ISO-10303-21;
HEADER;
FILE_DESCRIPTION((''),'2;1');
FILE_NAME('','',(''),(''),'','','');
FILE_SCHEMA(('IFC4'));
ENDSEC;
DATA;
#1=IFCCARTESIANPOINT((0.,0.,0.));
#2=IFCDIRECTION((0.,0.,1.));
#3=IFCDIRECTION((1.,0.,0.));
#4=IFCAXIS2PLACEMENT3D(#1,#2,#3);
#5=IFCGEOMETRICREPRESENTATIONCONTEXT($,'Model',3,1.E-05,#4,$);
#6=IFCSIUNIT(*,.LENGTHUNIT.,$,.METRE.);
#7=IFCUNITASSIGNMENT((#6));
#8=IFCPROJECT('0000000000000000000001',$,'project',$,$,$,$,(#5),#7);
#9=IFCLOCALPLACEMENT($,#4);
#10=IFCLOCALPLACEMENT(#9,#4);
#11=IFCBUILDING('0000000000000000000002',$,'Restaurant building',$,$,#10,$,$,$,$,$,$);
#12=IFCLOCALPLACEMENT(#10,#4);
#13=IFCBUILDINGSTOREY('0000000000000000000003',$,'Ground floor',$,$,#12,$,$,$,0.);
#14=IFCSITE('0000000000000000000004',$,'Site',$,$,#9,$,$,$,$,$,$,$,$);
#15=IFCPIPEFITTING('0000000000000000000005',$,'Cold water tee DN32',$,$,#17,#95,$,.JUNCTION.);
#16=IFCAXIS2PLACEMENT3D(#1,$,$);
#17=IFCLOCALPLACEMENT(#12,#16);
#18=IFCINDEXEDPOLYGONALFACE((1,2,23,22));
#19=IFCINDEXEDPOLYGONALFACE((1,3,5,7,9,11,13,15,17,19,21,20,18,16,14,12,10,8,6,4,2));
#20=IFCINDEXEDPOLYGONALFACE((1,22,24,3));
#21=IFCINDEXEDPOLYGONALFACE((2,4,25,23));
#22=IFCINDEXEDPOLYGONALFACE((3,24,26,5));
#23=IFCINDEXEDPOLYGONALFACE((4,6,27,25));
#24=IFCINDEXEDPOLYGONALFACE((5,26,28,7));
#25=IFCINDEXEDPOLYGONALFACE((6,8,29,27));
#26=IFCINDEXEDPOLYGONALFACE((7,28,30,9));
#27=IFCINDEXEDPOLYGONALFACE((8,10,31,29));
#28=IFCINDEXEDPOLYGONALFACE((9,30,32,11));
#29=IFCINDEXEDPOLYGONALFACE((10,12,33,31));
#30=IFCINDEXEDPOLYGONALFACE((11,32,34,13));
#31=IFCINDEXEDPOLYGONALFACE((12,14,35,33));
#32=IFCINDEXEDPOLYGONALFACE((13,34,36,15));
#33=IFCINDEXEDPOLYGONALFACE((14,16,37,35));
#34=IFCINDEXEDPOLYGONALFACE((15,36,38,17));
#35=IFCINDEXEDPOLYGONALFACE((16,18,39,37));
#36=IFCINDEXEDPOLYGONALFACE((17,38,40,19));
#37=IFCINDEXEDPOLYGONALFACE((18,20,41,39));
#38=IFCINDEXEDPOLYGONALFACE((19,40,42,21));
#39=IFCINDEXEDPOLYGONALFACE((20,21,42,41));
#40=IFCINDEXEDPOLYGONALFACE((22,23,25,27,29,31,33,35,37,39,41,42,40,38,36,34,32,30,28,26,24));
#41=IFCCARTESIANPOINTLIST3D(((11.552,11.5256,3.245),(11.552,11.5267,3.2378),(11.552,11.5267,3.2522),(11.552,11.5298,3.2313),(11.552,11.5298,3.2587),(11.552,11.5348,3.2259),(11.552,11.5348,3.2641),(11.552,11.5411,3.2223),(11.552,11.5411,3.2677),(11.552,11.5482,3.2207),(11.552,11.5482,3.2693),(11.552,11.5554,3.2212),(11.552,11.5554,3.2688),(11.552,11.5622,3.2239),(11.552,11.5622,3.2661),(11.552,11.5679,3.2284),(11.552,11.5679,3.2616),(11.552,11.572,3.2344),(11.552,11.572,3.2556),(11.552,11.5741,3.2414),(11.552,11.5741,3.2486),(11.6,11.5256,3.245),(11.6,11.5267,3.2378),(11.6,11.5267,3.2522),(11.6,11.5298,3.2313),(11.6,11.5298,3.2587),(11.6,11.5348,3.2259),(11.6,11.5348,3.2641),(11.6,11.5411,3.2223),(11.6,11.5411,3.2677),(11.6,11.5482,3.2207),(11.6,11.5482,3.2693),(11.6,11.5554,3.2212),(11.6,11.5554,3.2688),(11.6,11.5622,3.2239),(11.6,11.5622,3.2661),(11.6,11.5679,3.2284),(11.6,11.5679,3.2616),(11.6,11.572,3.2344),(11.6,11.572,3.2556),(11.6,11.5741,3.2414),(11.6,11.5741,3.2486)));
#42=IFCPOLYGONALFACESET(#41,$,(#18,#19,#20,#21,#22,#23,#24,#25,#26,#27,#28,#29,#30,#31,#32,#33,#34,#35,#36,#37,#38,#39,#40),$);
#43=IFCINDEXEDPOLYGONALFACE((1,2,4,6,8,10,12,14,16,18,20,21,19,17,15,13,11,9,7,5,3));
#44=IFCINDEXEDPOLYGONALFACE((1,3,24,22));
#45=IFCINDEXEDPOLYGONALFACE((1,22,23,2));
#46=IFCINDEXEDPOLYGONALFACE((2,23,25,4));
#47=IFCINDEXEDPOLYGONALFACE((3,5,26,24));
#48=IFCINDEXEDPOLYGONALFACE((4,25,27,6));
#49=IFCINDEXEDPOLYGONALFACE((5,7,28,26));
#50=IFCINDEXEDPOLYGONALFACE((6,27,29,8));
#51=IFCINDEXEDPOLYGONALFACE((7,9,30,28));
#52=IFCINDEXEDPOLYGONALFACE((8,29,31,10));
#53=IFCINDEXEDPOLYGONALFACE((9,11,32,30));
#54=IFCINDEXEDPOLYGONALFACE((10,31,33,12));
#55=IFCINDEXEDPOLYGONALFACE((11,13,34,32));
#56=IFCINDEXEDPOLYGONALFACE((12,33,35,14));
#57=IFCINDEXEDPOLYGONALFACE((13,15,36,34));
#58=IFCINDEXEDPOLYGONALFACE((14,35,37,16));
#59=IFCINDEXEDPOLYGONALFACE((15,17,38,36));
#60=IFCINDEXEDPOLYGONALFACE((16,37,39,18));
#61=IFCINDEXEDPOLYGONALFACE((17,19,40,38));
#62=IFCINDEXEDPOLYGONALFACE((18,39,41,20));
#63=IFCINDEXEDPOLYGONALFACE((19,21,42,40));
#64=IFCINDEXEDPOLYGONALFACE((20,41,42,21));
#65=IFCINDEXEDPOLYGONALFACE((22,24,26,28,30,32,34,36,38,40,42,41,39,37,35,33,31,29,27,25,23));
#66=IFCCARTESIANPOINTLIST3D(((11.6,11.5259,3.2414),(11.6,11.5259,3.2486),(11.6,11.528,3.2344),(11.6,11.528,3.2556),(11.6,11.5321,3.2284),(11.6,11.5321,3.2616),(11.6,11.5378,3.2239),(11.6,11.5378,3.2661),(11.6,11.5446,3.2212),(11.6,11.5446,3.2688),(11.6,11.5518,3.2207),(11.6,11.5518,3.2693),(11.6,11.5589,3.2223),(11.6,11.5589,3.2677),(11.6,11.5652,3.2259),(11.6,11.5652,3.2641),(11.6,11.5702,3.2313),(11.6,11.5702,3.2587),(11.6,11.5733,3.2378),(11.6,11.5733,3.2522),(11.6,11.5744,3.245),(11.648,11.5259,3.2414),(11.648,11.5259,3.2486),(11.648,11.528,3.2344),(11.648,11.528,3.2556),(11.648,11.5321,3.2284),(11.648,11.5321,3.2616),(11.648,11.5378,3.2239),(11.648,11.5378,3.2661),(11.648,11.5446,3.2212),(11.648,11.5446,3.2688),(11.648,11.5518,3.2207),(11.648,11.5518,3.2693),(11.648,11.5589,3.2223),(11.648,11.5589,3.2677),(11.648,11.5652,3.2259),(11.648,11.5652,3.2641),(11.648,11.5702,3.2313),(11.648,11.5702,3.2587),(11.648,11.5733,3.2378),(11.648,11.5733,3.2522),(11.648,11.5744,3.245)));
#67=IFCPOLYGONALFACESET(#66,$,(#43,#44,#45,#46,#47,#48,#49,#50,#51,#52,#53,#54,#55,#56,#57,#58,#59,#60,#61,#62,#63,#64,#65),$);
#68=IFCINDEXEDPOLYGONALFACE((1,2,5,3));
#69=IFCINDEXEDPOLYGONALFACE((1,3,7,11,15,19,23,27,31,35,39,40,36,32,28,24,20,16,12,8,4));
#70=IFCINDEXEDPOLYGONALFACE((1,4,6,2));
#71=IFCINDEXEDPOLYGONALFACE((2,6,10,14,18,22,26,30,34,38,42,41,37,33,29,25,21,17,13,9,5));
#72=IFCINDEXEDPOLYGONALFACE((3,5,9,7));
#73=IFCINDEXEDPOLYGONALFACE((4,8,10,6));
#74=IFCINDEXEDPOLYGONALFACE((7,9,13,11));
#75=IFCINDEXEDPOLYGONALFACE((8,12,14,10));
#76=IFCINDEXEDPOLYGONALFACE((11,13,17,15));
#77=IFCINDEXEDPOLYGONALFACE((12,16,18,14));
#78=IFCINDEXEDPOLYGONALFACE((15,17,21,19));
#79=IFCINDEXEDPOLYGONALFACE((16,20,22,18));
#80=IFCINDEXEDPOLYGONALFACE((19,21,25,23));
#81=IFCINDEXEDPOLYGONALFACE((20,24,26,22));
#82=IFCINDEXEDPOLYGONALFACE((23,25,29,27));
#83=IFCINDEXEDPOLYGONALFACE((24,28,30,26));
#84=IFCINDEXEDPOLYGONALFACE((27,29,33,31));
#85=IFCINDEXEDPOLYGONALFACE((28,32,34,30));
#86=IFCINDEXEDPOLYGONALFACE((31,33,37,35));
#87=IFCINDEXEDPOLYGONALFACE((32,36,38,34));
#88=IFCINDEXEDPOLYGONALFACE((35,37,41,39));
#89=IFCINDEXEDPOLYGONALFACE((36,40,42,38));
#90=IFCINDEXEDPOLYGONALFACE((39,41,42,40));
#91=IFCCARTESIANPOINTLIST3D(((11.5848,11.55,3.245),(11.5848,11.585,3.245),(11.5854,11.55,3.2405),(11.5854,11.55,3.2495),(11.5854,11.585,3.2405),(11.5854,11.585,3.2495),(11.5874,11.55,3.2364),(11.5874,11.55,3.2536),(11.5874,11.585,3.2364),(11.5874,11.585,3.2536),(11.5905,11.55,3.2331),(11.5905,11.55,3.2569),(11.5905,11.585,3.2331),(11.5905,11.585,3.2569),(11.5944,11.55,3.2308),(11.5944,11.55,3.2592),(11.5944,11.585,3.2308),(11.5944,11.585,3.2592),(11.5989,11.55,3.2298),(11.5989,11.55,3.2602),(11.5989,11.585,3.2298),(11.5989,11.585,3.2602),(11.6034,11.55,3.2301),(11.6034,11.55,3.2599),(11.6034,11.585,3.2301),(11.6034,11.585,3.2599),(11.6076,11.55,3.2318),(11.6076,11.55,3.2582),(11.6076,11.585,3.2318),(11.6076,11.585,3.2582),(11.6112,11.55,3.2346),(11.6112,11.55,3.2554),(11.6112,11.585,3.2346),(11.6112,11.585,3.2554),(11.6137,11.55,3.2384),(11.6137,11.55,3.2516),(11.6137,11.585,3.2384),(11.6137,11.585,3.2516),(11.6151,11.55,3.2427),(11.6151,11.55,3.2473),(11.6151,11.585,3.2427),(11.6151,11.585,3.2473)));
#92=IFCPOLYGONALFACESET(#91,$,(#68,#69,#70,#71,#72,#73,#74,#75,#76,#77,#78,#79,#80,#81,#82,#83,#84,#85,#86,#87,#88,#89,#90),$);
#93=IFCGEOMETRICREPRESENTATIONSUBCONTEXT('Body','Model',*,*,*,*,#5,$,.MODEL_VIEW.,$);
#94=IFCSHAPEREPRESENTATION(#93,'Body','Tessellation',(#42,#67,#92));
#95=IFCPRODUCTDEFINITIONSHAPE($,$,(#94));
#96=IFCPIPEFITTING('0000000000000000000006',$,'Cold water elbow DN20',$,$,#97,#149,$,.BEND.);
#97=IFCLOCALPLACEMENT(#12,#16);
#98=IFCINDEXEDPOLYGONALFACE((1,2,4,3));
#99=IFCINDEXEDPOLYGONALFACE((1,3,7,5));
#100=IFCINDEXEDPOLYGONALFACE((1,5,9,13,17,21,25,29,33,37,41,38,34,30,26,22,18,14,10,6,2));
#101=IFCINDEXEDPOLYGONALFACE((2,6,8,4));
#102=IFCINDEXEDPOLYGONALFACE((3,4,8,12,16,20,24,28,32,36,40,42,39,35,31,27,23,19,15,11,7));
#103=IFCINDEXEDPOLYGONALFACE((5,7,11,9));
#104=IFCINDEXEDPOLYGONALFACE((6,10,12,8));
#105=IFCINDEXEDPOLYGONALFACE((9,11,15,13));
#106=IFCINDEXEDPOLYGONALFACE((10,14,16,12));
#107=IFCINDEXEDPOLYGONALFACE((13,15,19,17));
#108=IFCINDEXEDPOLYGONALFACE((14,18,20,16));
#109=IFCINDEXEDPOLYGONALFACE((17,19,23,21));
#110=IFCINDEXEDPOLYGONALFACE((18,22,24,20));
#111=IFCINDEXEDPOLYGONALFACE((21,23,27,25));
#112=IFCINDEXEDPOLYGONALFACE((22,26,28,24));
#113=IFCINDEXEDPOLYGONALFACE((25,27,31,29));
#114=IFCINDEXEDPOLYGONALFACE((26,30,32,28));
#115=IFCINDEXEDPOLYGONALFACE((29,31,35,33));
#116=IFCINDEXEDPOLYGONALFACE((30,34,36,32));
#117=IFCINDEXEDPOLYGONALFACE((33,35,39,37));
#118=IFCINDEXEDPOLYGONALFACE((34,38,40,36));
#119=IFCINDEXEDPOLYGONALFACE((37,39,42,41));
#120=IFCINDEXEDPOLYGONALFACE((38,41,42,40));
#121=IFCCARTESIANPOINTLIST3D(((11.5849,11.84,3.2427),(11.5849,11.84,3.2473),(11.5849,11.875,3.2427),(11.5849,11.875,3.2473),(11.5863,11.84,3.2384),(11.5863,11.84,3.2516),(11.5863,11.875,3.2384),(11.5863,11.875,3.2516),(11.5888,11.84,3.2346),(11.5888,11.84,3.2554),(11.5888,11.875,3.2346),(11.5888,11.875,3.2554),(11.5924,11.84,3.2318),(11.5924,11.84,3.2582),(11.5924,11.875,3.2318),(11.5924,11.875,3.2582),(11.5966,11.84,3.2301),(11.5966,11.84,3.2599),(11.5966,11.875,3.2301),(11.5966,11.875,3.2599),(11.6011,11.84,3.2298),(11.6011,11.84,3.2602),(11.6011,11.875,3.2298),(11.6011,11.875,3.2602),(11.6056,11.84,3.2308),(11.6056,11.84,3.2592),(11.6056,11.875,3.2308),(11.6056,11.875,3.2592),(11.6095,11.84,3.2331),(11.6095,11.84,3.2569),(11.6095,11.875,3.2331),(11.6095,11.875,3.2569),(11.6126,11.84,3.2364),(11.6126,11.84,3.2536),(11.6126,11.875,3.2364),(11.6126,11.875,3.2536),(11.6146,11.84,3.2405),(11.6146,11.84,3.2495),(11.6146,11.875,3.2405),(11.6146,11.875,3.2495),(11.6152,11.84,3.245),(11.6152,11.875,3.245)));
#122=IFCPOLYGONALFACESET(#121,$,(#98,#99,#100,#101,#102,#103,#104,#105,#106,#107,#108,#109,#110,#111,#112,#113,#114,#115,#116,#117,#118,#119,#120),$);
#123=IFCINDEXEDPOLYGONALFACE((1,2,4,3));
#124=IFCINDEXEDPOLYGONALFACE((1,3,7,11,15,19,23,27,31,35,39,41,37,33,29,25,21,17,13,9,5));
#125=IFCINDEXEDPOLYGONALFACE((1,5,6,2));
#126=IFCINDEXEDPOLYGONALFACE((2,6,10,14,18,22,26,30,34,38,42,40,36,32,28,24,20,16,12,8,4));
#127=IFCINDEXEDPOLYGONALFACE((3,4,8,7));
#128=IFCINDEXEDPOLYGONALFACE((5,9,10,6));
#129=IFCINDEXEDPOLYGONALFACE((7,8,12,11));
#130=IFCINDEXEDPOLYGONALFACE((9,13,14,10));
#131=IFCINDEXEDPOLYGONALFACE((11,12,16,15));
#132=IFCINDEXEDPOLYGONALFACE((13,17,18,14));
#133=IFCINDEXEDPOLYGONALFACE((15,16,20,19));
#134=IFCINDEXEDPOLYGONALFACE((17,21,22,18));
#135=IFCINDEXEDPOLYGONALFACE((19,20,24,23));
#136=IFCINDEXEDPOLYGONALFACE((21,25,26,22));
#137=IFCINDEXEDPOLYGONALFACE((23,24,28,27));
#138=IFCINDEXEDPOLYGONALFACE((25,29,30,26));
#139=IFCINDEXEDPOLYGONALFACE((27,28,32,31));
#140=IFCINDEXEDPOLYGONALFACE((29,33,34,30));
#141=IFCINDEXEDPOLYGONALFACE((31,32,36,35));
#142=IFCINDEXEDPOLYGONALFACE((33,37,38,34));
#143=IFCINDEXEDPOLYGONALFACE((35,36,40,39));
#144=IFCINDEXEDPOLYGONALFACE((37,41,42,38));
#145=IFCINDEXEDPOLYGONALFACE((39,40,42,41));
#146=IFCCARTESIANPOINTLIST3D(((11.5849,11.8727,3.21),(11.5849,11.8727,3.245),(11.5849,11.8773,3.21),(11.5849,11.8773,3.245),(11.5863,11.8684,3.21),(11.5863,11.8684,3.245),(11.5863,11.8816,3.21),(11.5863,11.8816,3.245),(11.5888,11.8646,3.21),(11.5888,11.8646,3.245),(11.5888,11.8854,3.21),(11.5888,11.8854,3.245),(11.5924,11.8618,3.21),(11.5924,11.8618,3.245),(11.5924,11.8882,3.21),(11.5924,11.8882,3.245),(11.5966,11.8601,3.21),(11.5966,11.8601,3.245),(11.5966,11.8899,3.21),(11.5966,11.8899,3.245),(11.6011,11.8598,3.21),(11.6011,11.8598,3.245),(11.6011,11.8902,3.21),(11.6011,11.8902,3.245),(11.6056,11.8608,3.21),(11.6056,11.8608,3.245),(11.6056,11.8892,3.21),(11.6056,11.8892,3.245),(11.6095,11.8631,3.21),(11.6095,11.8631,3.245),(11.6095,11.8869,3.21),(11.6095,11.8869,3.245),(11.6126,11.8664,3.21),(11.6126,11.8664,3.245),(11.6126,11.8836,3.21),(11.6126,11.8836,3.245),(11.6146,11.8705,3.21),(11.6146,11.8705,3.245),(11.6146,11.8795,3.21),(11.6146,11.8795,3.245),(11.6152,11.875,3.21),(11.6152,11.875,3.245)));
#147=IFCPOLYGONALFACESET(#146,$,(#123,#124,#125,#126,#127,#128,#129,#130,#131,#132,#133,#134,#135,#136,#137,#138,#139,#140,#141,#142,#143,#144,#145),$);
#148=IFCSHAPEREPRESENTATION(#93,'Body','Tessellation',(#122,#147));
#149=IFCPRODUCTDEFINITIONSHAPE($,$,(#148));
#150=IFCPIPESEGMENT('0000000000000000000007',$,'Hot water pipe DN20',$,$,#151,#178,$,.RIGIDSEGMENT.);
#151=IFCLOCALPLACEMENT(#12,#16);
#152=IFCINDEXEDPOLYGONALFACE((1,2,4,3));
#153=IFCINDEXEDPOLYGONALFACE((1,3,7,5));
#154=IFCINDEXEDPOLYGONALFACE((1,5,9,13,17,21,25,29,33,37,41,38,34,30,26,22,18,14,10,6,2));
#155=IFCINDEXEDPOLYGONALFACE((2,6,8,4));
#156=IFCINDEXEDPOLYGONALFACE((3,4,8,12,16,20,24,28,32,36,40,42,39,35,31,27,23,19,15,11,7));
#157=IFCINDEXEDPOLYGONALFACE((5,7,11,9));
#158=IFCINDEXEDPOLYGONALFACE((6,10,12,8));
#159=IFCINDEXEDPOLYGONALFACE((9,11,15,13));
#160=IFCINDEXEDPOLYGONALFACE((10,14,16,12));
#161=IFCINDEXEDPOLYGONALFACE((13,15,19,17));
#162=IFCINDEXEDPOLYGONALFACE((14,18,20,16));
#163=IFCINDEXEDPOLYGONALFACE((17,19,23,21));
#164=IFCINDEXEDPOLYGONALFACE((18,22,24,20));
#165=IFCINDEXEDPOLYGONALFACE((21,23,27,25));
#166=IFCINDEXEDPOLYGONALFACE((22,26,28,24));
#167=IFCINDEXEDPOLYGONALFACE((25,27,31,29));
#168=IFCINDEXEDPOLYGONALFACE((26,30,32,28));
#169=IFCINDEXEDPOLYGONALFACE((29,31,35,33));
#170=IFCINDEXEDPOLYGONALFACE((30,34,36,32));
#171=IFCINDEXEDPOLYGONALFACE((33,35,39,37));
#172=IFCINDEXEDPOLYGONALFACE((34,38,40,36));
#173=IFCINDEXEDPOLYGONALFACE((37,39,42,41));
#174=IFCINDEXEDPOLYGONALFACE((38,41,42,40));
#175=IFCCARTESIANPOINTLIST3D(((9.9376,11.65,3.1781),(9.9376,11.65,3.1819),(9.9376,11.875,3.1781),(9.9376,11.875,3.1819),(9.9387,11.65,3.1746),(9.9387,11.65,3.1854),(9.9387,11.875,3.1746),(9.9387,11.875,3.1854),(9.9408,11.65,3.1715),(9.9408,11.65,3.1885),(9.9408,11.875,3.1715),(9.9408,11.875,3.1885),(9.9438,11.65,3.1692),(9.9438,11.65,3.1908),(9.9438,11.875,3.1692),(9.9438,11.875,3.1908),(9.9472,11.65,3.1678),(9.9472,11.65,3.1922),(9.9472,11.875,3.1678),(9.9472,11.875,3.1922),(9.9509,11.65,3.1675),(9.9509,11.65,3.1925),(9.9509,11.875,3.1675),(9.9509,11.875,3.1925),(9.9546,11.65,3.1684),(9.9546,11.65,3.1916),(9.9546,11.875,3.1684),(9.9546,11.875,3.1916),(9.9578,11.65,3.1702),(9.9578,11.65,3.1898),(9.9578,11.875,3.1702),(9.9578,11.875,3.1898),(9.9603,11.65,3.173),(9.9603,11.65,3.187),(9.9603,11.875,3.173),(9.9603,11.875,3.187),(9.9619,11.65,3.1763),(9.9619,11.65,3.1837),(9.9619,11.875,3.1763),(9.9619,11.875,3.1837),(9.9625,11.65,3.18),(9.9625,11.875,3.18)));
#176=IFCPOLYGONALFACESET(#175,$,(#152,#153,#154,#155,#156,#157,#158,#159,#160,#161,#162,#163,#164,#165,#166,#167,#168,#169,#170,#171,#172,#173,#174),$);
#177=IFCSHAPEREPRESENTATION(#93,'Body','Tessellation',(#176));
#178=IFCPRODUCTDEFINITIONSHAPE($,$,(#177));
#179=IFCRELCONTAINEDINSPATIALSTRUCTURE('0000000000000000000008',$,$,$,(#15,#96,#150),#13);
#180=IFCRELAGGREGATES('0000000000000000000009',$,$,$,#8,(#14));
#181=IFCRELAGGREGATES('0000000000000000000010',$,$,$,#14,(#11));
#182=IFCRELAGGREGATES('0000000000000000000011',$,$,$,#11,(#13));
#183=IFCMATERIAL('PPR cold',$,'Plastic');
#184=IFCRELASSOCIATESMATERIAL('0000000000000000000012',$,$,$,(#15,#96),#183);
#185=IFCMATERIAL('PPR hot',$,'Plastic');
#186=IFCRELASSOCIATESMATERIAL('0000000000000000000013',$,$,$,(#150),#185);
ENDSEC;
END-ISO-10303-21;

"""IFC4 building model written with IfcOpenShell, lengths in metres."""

from ifc_helpers import new_model, si_unit, frame, origin_with_axes, origin_2d, place, context, subcontext, project, spatial, circle, extrude, material, element, save


model = new_model("IFC4")

# Units and contexts
model_context = context("Model", 3, precision=1e-05, world=origin_with_axes())
body_context = subcontext(model_context, "Body", "Model", "MODEL_VIEW")
ifc_project = project(units=[si_unit("LENGTHUNIT", "METRE")], contexts=[model_context])

# Site, building, storey
site_placement = place(None, origin_with_axes())
site = spatial("IfcSite", under=ifc_project, at=site_placement, Name="Site")
building_placement = place(site_placement, origin_with_axes())
building = spatial("IfcBuilding", under=site, at=building_placement, Name="Restaurant building")
storey_placement = place(building_placement, origin_with_axes())
storey = spatial("IfcBuildingStorey", under=building, at=storey_placement, Name="Ground floor", Elevation=0.0)

# Shared definitions
ifc_material_1 = material(Name="PPR cold", Category="Plastic")

# Pipe fittings
pipe_fitting_1_placement = place(storey_placement, frame((11.6, 11.55, 3.245)))
element("IfcPipeFitting", 1, at=pipe_fitting_1_placement, inside=storey, material=ifc_material_1, Name="Cold water tee DN32", PredefinedType="JUNCTION", context=body_context, shape_type="SweptSolid", body=[
    extrude(circle(Radius=0.0244, at=origin_2d()), frame((0.0, 0.0, 0.0), z_axis=(-1.0, 0.0, 0.0), x_axis=(0.0, -1.0, 0.0)), (0.0, 0.0, 1.0), 0.048),
    extrude(circle(Radius=0.0244, at=origin_2d()), frame((0.0, 0.0, 0.0), z_axis=(1.0, 0.0, 0.0), x_axis=(0.0, 1.0, 0.0)), (0.0, 0.0, 1.0), 0.048),
    extrude(circle(Radius=0.0152, at=origin_2d()), frame((0.0, 0.0, 0.0), z_axis=(0.0, 1.0, 0.0), x_axis=(-1.0, 0.0, 0.0)), (0.0, 0.0, 1.0), 0.035),
])
pipe_fitting_2_placement = place(storey_placement, frame((11.6, 11.875, 3.245)))
element("IfcPipeFitting", 2, at=pipe_fitting_2_placement, inside=storey, material=ifc_material_1, Name="Cold water elbow DN20", PredefinedType="BEND", context=body_context, shape_type="SweptSolid", body=[
    extrude(circle(Radius=0.0152, at=origin_2d()), frame((0.0, 0.0, 0.0), z_axis=(0.0, -1.0, 0.0), x_axis=(1.0, 0.0, 0.0)), (0.0, 0.0, 1.0), 0.035),
    extrude(circle(Radius=0.0152, at=origin_2d()), frame((0.0, 0.0, 0.0), z_axis=(0.0, 0.0, -1.0), x_axis=(1.0, 0.0, 0.0)), (0.0, 0.0, 1.0), 0.035),
])

# Pipe segment
ifc_material_2 = material(Name="PPR hot", Category="Plastic")
pipe_segment_1_placement = place(storey_placement, frame((9.95, 11.875, 3.18)))
element("IfcPipeSegment", 3, at=pipe_segment_1_placement, inside=storey, material=ifc_material_2, Name="Hot water pipe DN20", PredefinedType="RIGIDSEGMENT", context=body_context, shape_type="SweptSolid", body=[
    extrude(circle(Radius=0.0125, at=origin_2d()), frame((0.0, 0.0, 0.0), z_axis=(0.0, -1.0, 0.0), x_axis=(1.0, 0.0, 0.0)), (0.0, 0.0, 1.0), 0.225),
])

save(model, "model.ifc")
